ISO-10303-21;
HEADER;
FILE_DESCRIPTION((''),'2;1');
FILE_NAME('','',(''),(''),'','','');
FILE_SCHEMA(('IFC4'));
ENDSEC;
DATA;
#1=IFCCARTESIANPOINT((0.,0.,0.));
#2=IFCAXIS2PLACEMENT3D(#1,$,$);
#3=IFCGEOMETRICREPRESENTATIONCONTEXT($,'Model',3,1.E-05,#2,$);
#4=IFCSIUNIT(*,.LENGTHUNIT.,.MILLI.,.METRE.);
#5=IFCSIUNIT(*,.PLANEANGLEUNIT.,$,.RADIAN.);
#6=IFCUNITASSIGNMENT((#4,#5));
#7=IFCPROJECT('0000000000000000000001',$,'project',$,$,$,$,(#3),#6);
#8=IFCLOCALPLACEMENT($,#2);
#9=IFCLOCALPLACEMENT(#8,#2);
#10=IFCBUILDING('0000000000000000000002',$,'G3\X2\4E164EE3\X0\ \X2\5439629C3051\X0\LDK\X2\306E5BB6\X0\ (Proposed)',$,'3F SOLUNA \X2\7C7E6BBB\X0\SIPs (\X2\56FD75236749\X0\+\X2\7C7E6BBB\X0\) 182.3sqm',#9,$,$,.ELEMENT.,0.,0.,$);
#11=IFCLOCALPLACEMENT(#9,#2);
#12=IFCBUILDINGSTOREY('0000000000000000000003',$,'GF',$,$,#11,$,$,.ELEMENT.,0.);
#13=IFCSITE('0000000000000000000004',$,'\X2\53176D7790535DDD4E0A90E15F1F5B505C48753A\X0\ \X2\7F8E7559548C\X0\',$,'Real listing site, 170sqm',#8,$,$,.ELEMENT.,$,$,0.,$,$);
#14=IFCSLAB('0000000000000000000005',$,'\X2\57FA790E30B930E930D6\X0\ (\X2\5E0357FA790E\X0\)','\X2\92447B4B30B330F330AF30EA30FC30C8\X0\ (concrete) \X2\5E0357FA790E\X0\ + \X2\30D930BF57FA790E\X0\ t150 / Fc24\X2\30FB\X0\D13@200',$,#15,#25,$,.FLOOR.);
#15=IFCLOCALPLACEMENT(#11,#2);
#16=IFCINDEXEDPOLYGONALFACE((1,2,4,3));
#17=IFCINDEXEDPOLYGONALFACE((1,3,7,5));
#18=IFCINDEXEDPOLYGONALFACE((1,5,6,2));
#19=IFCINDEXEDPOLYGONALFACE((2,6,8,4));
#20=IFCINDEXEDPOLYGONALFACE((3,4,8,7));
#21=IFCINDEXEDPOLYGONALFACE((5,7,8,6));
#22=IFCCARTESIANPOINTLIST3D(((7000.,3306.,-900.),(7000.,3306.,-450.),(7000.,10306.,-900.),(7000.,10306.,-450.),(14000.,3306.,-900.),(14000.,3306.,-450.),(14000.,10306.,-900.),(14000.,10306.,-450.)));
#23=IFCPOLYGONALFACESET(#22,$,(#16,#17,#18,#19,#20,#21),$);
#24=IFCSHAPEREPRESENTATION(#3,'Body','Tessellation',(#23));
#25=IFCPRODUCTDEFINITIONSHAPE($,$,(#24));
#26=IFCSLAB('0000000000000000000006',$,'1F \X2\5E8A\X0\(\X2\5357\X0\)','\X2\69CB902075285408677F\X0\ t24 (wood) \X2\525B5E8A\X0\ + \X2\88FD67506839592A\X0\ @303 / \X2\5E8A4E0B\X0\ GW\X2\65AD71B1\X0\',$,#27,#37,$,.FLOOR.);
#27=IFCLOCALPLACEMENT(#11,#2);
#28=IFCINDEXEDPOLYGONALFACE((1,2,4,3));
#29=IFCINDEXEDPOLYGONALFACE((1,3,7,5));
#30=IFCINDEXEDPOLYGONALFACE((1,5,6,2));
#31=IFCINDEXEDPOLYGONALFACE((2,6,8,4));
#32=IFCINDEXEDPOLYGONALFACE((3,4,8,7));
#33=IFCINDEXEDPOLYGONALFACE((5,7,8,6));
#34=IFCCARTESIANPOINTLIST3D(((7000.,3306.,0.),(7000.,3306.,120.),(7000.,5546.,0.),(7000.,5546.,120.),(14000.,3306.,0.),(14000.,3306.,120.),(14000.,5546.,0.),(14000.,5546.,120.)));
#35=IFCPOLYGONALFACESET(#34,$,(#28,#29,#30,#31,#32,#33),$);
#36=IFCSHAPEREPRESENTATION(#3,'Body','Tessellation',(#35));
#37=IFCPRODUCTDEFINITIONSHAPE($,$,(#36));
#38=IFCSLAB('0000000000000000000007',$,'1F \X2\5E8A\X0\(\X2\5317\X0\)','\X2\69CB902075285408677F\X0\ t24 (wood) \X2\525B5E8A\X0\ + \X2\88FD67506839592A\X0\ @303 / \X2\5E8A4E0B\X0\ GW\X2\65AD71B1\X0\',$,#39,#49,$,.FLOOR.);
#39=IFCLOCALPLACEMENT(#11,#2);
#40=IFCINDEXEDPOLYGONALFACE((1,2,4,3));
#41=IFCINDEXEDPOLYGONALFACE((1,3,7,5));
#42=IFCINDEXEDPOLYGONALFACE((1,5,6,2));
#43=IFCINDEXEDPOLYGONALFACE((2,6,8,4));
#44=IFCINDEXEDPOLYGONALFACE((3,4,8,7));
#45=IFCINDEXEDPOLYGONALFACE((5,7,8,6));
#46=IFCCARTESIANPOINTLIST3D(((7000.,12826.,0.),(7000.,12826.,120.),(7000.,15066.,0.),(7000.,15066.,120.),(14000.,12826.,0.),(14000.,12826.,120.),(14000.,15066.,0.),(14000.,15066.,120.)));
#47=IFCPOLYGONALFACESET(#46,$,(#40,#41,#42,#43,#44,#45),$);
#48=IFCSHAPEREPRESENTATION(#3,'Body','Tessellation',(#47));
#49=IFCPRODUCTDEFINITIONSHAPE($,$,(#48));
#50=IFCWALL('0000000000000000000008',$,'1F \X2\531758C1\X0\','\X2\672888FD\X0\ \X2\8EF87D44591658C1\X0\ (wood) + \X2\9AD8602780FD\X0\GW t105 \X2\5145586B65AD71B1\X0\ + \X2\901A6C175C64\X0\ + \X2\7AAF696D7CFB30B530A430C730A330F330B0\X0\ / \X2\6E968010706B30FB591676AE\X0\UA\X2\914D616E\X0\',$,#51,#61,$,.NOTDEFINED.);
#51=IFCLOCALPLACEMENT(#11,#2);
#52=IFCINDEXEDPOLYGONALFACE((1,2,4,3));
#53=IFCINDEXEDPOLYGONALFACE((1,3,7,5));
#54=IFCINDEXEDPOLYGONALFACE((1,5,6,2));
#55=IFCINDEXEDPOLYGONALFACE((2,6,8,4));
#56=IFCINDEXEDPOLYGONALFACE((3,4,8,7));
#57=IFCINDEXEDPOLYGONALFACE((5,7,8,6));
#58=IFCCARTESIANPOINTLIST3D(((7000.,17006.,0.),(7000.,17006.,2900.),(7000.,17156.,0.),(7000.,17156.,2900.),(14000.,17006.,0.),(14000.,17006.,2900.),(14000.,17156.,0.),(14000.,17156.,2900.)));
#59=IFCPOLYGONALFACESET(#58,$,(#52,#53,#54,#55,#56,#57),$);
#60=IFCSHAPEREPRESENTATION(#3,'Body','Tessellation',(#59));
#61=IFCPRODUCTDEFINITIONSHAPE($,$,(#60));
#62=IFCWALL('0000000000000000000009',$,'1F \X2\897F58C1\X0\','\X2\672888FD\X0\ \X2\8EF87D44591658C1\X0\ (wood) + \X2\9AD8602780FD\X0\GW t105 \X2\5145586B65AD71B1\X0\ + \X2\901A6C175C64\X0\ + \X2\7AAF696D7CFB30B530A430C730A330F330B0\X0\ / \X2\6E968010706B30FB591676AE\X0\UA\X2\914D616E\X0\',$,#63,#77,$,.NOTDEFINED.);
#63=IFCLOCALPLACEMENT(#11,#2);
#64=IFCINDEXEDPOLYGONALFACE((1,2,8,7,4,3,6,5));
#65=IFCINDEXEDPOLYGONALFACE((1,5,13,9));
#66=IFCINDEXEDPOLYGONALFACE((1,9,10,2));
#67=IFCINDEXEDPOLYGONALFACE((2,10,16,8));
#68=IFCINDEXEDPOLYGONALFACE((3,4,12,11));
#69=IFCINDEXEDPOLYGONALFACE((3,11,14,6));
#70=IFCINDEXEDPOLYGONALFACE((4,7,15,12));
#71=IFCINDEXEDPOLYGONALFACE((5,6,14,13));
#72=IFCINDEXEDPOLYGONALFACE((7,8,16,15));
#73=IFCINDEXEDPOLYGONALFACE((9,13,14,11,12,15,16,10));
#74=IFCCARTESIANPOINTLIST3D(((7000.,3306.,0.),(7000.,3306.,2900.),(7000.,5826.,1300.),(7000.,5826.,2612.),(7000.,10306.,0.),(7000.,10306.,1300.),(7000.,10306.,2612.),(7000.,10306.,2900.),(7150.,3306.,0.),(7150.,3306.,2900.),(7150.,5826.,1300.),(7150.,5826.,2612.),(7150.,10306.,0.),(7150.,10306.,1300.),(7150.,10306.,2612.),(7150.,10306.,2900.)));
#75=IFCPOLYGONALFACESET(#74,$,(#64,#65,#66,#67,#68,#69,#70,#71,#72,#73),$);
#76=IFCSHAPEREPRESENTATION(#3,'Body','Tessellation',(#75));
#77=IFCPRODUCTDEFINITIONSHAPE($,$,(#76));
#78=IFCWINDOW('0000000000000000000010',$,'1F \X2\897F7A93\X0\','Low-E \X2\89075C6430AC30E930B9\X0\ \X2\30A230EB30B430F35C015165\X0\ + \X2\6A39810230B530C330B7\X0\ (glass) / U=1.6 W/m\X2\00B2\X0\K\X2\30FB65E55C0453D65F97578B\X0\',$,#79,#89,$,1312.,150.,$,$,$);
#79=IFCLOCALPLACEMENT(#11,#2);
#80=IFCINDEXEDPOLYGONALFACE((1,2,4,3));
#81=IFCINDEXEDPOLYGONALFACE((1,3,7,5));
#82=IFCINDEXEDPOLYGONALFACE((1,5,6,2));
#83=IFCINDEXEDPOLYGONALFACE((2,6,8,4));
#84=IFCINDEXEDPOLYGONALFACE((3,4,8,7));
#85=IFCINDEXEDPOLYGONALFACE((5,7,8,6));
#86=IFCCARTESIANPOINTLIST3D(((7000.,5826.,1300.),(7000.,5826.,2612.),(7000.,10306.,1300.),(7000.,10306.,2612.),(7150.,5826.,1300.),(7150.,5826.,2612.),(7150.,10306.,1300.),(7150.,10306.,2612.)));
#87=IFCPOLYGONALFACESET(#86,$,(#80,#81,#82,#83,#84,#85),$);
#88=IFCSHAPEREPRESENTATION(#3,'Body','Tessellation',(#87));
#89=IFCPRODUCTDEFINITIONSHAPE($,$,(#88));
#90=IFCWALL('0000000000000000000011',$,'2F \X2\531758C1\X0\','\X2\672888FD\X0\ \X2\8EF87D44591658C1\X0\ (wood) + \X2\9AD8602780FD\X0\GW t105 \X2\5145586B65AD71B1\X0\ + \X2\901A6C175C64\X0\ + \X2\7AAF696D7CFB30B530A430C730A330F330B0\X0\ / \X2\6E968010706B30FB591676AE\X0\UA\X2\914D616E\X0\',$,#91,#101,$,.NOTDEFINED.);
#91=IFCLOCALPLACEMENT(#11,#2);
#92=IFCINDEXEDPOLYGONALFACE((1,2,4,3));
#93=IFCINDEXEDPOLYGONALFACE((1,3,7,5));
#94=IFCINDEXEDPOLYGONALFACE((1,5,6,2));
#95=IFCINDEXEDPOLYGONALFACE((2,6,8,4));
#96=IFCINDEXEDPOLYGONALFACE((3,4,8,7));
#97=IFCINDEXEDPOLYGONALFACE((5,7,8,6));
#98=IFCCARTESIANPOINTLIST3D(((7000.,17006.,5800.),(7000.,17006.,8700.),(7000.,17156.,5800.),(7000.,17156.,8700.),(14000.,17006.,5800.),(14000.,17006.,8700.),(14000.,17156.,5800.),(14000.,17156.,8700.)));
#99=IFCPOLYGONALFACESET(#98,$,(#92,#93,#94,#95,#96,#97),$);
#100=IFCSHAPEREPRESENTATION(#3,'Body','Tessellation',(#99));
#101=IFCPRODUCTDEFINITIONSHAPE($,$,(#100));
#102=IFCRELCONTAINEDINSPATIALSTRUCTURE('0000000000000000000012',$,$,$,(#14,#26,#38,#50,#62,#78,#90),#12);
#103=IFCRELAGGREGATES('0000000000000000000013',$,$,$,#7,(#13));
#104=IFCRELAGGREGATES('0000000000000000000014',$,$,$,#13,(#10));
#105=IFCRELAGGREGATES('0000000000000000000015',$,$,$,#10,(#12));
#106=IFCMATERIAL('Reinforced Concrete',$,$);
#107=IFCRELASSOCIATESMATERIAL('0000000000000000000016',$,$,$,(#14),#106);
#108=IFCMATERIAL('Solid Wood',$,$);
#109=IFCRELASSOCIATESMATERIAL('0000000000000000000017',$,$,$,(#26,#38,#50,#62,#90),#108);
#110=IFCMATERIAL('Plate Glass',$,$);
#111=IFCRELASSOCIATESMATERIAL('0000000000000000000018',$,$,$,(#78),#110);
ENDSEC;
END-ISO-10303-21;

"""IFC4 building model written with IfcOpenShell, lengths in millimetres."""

from ifc_helpers import new_model, si_unit, frame, frame_2d, origin, place, context, project, spatial, rectangle, extrude, material, element, fill, save


model = new_model("IFC4")

# Units and contexts
model_context = context("Model", 3, precision=1e-05, world=origin())
ifc_project = project(units=[si_unit("LENGTHUNIT", "METRE", prefix="MILLI"), si_unit("PLANEANGLEUNIT", "RADIAN")], contexts=[model_context])

# Site, building, storey
site_placement = place(None, origin())
site = spatial("IfcSite", under=ifc_project, at=site_placement, Name="北海道川上郡弟子屈町 美留和", ObjectType="Real listing site, 170sqm", CompositionType="ELEMENT", RefElevation=0.0)
building_placement = place(site_placement, origin())
building = spatial("IfcBuilding", under=site, at=building_placement, Name="G3世代 吹抜けLDKの家 (Proposed)", ObjectType="3F SOLUNA 籾殻SIPs (国産杉+籾殻) 182.3sqm", CompositionType="ELEMENT", ElevationOfRefHeight=0.0, ElevationOfTerrain=0.0)
storey_placement = place(building_placement, origin())
storey = spatial("IfcBuildingStorey", under=building, at=storey_placement, Name="GF", CompositionType="ELEMENT", Elevation=0.0)

# Slabs
ifc_material_1 = material(Name="Reinforced Concrete")
slab_1_placement = place(storey_placement, frame((3500.0, 1653.0, -450.0)))
element("IfcSlab", 1, at=slab_1_placement, inside=storey, material=ifc_material_1, Name="基礎スラブ (布基礎)", Description="鉄筋コンクリート (concrete) 布基礎 + ベタ基礎 t150 / Fc24・D13@200", PredefinedType="FLOOR", context=model_context, shape_type="SweptSolid", body=[
    extrude(rectangle(XDim=7000.0, YDim=7000.0, at=frame_2d((3500.0, 3500.0))), frame((3500.0, 1653.0, -450.0)), (0.0, 0.0, 1.0), 450.0),
])
ifc_material_2 = material(Name="Solid Wood")
slab_2_placement = place(storey_placement, frame((3500.0, 1653.0, 0.0)))
element("IfcSlab", 2, at=slab_2_placement, inside=storey, material=ifc_material_2, Name="1F 床(南)", Description="構造用合板 t24 (wood) 剛床 + 製材根太 @303 / 床下 GW断熱", PredefinedType="FLOOR", context=model_context, shape_type="SweptSolid", body=[
    extrude(rectangle(XDim=7000.0, YDim=2240.0, at=frame_2d((3500.0, 1120.0))), frame((3500.0, 1653.0, 0.0)), (0.0, 0.0, 1.0), 120.0),
])
slab_3_placement = place(storey_placement, frame((3500.0, 6413.0, 0.0)))
element("IfcSlab", 3, at=slab_3_placement, inside=storey, material=ifc_material_2, Name="1F 床(北)", Description="構造用合板 t24 (wood) 剛床 + 製材根太 @303 / 床下 GW断熱", PredefinedType="FLOOR", context=model_context, shape_type="SweptSolid", body=[
    extrude(rectangle(XDim=7000.0, YDim=2240.0, at=frame_2d((3500.0, 1120.0))), frame((3500.0, 6413.0, 0.0)), (0.0, 0.0, 1.0), 120.0),
])

# Shared definitions
ifc_material_3 = material(Name="Plate Glass")

# Wall
wall_1_placement = place(storey_placement, frame((3500.0, 8503.0, 0.0)))
element("IfcWall", 4, at=wall_1_placement, inside=storey, material=ifc_material_2, Name="1F 北壁", Description="木製 軸組外壁 (wood) + 高性能GW t105 充填断熱 + 通気層 + 窯業系サイディング / 準耐火・外皮UA配慮", PredefinedType="NOTDEFINED", context=model_context, shape_type="SweptSolid", body=[
    extrude(rectangle(XDim=7000.0, YDim=150.0, at=frame_2d((3500.0, 75.0))), frame((3500.0, 8503.0, 0.0)), (0.0, 0.0, 1.0), 2900.0),
])

# Wall, opening, window
wall_2_placement = place(storey_placement, frame((3500.0, 1653.0, 0.0)))
wall_2 = element("IfcWall", 5, at=wall_2_placement, inside=storey, material=ifc_material_2, Name="1F 西壁", Description="木製 軸組外壁 (wood) + 高性能GW t105 充填断熱 + 通気層 + 窯業系サイディング / 準耐火・外皮UA配慮", PredefinedType="NOTDEFINED", context=model_context, shape_type="SweptSolid", body=[
    extrude(rectangle(XDim=150.0, YDim=7000.0, at=frame_2d((75.0, 3500.0))), frame((3500.0, 1653.0, 0.0)), (0.0, 0.0, 1.0), 2900.0),
])
opening_1_placement = place(storey_placement, frame((3500.0, 2913.0, 650.0)))
opening_1 = element("IfcOpeningElement", 6, at=opening_1_placement, cuts=wall_2, PredefinedType="NOTDEFINED", context=model_context, shape_type="SweptSolid", body=[
    extrude(rectangle(XDim=150.0, YDim=4480.0, at=frame_2d((75.0, 2240.0))), frame((3500.0, 2913.0, 650.0)), (0.0, 0.0, 1.0), 1312.0),
])
window_1_placement = place(storey_placement, frame((3500.0, 2913.0, 650.0)))
window_1 = element("IfcWindow", 7, at=window_1_placement, inside=storey, material=ifc_material_3, Name="1F 西窓", Description="Low-E 複層ガラス アルゴン封入 + 樹脂サッシ (glass) / U=1.6 W/m²K・日射取得型", OverallHeight=1312.0, OverallWidth=150.0, context=model_context, shape_type="SweptSolid", body=[
    extrude(rectangle(XDim=150.0, YDim=4480.0, at=frame_2d((75.0, 2240.0))), frame((3500.0, 2913.0, 650.0)), (0.0, 0.0, 1.0), 1312.0),
])
fill(opening_1, window_1)

# Wall
wall_3_placement = place(storey_placement, frame((3500.0, 8503.0, 2900.0)))
element("IfcWall", 8, at=wall_3_placement, inside=storey, material=ifc_material_2, Name="2F 北壁", Description="木製 軸組外壁 (wood) + 高性能GW t105 充填断熱 + 通気層 + 窯業系サイディング / 準耐火・外皮UA配慮", PredefinedType="NOTDEFINED", context=model_context, shape_type="SweptSolid", body=[
    extrude(rectangle(XDim=7000.0, YDim=150.0, at=frame_2d((3500.0, 75.0))), frame((3500.0, 8503.0, 2900.0)), (0.0, 0.0, 1.0), 2900.0),
])

save(model, "model.ifc")
